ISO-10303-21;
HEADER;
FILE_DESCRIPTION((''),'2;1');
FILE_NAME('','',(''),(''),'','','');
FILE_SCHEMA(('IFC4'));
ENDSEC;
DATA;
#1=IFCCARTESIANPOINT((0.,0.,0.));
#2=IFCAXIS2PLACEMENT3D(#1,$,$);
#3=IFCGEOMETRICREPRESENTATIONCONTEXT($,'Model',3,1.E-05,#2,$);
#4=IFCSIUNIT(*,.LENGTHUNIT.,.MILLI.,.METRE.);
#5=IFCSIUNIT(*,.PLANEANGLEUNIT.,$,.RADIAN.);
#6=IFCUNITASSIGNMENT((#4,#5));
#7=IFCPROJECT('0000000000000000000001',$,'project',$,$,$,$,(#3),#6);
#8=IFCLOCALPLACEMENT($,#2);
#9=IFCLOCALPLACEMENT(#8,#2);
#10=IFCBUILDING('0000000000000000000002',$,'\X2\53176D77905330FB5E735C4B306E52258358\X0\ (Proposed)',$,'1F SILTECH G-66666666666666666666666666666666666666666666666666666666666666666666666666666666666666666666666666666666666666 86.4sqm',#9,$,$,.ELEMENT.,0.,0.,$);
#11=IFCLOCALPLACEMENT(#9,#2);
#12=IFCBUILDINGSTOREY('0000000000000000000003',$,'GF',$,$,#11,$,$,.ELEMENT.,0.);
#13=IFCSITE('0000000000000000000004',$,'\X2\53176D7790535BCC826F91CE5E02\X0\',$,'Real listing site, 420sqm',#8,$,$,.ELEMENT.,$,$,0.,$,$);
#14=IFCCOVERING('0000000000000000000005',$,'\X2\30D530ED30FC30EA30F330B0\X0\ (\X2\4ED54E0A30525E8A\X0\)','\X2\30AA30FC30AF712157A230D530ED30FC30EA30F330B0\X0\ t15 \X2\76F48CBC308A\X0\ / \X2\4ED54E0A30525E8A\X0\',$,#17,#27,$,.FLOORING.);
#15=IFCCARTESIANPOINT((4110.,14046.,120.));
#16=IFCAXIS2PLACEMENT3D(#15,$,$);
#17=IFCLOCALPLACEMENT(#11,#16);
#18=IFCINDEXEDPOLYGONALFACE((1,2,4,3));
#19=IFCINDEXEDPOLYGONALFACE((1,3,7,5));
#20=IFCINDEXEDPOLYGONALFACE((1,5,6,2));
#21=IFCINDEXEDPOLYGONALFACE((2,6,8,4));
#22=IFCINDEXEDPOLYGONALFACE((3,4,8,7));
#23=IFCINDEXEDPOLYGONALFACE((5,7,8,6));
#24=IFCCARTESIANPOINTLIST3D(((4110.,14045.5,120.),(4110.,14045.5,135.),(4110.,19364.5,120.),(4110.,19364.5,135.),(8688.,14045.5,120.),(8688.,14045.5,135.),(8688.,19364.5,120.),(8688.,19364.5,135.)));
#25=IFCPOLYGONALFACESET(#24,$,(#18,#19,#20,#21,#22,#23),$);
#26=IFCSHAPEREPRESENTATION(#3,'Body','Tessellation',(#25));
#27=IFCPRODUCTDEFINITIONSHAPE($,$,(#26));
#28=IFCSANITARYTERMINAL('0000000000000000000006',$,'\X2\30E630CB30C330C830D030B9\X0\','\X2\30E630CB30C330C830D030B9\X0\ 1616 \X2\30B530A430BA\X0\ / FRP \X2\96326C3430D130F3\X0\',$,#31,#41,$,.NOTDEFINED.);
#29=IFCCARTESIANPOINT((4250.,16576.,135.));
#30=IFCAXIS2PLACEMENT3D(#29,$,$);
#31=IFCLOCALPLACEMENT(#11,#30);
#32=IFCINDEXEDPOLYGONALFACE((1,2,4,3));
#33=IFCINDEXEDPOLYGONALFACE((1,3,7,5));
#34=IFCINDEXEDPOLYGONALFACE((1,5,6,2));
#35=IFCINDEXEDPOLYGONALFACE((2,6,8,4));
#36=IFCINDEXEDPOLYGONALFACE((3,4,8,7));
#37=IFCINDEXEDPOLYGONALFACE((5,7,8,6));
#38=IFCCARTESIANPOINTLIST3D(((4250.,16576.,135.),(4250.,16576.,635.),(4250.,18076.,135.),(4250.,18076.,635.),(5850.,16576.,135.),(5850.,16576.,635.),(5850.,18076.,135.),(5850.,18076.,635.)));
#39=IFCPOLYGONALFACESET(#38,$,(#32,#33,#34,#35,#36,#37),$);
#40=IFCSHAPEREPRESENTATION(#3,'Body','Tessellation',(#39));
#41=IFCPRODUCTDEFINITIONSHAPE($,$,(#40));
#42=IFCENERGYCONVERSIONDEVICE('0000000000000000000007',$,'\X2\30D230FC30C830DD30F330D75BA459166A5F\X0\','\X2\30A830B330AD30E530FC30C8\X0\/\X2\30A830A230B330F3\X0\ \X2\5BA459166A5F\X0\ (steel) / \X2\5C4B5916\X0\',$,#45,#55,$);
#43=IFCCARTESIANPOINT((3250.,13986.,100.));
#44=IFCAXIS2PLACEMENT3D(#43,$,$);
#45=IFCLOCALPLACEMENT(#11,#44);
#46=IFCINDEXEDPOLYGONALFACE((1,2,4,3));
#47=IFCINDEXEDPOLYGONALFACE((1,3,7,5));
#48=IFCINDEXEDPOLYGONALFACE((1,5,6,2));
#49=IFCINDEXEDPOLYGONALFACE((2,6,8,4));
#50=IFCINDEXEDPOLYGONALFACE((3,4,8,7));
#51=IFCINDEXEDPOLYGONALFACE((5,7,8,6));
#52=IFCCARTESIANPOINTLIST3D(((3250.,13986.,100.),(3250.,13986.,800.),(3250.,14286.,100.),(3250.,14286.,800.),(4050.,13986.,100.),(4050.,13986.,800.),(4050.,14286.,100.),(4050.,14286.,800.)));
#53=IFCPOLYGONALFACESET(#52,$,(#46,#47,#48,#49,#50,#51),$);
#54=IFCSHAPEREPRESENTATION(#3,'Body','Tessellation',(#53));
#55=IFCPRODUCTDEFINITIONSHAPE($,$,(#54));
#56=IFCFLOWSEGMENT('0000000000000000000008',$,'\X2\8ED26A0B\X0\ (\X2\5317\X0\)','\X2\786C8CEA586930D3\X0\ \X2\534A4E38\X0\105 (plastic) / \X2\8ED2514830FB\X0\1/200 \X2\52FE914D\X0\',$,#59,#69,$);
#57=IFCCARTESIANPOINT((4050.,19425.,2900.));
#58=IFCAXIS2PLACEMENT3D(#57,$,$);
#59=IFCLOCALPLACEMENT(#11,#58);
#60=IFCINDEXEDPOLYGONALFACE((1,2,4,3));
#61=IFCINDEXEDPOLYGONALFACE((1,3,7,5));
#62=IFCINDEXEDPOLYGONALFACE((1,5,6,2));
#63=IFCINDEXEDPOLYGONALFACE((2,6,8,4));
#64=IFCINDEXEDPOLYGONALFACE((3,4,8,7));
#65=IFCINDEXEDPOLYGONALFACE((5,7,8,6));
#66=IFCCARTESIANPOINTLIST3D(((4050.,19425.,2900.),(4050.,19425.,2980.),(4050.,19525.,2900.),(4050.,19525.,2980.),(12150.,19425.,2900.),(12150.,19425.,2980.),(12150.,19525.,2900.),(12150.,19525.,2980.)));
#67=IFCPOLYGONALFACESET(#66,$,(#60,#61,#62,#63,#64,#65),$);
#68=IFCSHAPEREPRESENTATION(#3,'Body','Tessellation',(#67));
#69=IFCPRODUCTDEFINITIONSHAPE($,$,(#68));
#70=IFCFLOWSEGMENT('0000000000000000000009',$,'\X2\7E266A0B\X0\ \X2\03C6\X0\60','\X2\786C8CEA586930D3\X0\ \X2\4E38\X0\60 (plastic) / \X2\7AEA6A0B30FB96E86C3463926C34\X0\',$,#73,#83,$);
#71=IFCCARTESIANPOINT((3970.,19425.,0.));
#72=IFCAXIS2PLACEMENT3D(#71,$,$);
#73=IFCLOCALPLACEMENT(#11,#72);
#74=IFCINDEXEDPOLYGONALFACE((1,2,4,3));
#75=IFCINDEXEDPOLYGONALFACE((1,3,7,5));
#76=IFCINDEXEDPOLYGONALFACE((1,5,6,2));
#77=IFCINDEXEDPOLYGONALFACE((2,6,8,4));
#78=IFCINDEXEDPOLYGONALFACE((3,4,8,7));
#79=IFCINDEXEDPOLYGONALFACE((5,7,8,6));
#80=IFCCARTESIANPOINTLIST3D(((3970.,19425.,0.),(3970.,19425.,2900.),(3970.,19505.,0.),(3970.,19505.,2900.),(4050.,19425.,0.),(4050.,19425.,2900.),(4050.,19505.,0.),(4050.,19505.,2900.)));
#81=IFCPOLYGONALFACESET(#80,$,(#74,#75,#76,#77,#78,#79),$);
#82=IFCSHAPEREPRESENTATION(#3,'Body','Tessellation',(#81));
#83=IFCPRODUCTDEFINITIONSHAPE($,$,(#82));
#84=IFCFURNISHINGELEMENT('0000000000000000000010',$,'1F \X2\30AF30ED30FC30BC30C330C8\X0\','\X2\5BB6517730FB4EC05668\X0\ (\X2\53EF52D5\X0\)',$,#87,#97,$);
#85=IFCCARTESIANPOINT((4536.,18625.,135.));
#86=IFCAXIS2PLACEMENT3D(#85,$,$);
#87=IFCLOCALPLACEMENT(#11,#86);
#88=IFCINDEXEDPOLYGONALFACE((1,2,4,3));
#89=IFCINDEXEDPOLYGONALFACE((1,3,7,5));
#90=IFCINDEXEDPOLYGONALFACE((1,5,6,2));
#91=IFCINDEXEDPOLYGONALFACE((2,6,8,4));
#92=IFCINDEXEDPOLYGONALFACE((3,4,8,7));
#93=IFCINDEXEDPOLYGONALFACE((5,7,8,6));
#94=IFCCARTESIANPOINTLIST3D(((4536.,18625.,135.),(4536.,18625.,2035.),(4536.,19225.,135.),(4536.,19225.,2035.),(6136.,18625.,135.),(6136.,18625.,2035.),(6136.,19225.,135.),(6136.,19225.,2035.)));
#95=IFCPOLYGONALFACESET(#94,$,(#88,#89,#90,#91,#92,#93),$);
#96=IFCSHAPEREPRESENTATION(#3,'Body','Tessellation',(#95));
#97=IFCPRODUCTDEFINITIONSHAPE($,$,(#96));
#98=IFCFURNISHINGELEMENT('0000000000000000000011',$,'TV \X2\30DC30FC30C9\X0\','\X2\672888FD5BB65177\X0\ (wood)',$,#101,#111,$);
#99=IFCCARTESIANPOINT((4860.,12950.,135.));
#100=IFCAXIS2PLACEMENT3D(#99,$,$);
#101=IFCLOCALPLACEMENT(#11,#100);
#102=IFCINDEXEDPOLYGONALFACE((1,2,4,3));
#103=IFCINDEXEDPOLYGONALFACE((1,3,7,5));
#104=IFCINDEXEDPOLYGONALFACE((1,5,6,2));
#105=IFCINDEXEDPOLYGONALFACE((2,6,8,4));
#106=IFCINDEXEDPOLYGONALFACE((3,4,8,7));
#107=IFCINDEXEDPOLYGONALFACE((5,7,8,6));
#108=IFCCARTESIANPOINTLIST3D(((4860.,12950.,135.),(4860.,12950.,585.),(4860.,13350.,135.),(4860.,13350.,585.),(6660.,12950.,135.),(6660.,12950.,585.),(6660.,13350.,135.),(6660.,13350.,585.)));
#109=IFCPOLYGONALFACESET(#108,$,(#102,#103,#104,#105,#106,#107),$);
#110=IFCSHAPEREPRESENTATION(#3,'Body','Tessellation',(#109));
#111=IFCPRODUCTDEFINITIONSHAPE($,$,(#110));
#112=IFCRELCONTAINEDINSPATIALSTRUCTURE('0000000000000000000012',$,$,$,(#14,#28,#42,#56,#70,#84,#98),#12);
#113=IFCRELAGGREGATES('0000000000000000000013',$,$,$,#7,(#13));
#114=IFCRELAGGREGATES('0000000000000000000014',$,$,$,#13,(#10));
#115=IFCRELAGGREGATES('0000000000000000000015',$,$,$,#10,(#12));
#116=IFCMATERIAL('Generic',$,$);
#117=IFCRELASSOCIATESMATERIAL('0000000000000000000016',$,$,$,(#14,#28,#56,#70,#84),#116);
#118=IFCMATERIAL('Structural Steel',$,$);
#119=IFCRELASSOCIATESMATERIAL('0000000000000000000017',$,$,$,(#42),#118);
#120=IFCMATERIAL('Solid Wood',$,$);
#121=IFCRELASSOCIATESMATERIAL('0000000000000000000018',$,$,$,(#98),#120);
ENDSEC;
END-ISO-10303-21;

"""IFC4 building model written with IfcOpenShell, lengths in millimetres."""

from ifc_helpers import new_model, si_unit, frame, frame_2d, origin, place, context, project, spatial, rectangle, extrude, material, element, save


model = new_model("IFC4")

# Units and contexts
model_context = context("Model", 3, precision=1e-05, world=origin())
ifc_project = project(units=[si_unit("LENGTHUNIT", "METRE", prefix="MILLI"), si_unit("PLANEANGLEUNIT", "RADIAN")], contexts=[model_context])

# Site, building, storey
site_placement = place(None, origin())
site = spatial("IfcSite", under=ifc_project, at=site_placement, Name="北海道富良野市", ObjectType="Real listing site, 420sqm", CompositionType="ELEMENT", RefElevation=0.0)
building_placement = place(site_placement, origin())
building = spatial("IfcBuilding", under=site, at=building_placement, Name="北海道・平屋の別荘 (Proposed)", ObjectType="1F SILTECH G-66666666666666666666666666666666666666666666666666666666666666666666666666666666666666666666666666666666666666 86.4sqm", CompositionType="ELEMENT", ElevationOfRefHeight=0.0, ElevationOfTerrain=0.0)
storey_placement = place(building_placement, origin())
storey = spatial("IfcBuildingStorey", under=building, at=storey_placement, Name="GF", CompositionType="ELEMENT", Elevation=0.0)

# Shared definitions
ifc_material_1 = material(Name="Solid Wood")

# Shared definitions
ifc_material_2 = material(Name="Structural Steel")

# Covering
ifc_material_3 = material(Name="Generic")
covering_placement = place(storey_placement, frame((4110.0, 14046.0, 120.0)))
element("IfcCovering", 1, at=covering_placement, inside=storey, material=ifc_material_3, Name="フローリング (仕上げ床)", Description="オーク無垢フローリング t15 直貼り / 仕上げ床", PredefinedType="FLOORING", context=model_context, shape_type="SweptSolid", body=[
    extrude(rectangle(XDim=4578.0, YDim=5319.0, at=frame_2d((2289.0, 2659.0))), frame((4110.0, 14046.0, 120.0)), (0.0, 0.0, 1.0), 15.0),
])

# Sanitary terminal
sanitary_terminal_placement = place(storey_placement, frame((4250.0, 16576.0, 135.0)))
element("IfcSanitaryTerminal", 2, at=sanitary_terminal_placement, inside=storey, material=ifc_material_3, Name="ユニットバス", Description="ユニットバス 1616 サイズ / FRP 防水パン", PredefinedType="NOTDEFINED", context=model_context, shape_type="SweptSolid", body=[
    extrude(rectangle(XDim=1600.0, YDim=1500.0, at=frame_2d((800.0, 750.0))), frame((4250.0, 16576.0, 135.0)), (0.0, 0.0, 1.0), 500.0),
])

# Energy conversion device
energy_conversion_device_placement = place(storey_placement, frame((3250.0, 13986.0, 100.0)))
element("IfcEnergyConversionDevice", 3, at=energy_conversion_device_placement, inside=storey, material=ifc_material_2, Name="ヒートポンプ室外機", Description="エコキュート/エアコン 室外機 (steel) / 屋外", context=model_context, shape_type="SweptSolid", body=[
    extrude(rectangle(XDim=800.0, YDim=300.0, at=frame_2d((400.0, 150.0))), frame((3250.0, 13986.0, 100.0)), (0.0, 0.0, 1.0), 700.0),
])

# Flow segments
flow_segment_1_placement = place(storey_placement, frame((4050.0, 19425.0, 2900.0)))
element("IfcFlowSegment", 4, at=flow_segment_1_placement, inside=storey, material=ifc_material_3, Name="軒樋 (北)", Description="硬質塩ビ 半丸105 (plastic) / 軒先・1/200 勾配", context=model_context, shape_type="SweptSolid", body=[
    extrude(rectangle(XDim=8100.0, YDim=100.0, at=frame_2d((4050.0, 50.0))), frame((4050.0, 19425.0, 2900.0)), (0.0, 0.0, 1.0), 80.0),
])
flow_segment_2_placement = place(storey_placement, frame((3970.0, 19425.0, 0.0)))
element("IfcFlowSegment", 5, at=flow_segment_2_placement, inside=storey, material=ifc_material_3, Name="縦樋 φ60", Description="硬質塩ビ 丸60 (plastic) / 竪樋・雨水排水", context=model_context, shape_type="SweptSolid", body=[
    extrude(rectangle(XDim=80.0, YDim=80.0, at=frame_2d((40.0, 40.0))), frame((3970.0, 19425.0, 0.0)), (0.0, 0.0, 1.0), 2900.0),
])

# Furnishing elements
furnishing_1_placement = place(storey_placement, frame((4536.0, 18625.0, 135.0)))
element("IfcFurnishingElement", 6, at=furnishing_1_placement, inside=storey, material=ifc_material_3, Name="1F クローゼット", Description="家具・什器 (可動)", context=model_context, shape_type="SweptSolid", body=[
    extrude(rectangle(XDim=1600.0, YDim=600.0, at=frame_2d((800.0, 300.0))), frame((4536.0, 18625.0, 135.0)), (0.0, 0.0, 1.0), 1900.0),
])
furnishing_2_placement = place(storey_placement, frame((4860.0, 12950.0, 135.0)))
element("IfcFurnishingElement", 7, at=furnishing_2_placement, inside=storey, material=ifc_material_1, Name="TV ボード", Description="木製家具 (wood)", context=model_context, shape_type="SweptSolid", body=[
    extrude(rectangle(XDim=1800.0, YDim=400.0, at=frame_2d((900.0, 200.0))), frame((4860.0, 12950.0, 135.0)), (0.0, 0.0, 1.0), 450.0),
])

save(model, "model.ifc")
